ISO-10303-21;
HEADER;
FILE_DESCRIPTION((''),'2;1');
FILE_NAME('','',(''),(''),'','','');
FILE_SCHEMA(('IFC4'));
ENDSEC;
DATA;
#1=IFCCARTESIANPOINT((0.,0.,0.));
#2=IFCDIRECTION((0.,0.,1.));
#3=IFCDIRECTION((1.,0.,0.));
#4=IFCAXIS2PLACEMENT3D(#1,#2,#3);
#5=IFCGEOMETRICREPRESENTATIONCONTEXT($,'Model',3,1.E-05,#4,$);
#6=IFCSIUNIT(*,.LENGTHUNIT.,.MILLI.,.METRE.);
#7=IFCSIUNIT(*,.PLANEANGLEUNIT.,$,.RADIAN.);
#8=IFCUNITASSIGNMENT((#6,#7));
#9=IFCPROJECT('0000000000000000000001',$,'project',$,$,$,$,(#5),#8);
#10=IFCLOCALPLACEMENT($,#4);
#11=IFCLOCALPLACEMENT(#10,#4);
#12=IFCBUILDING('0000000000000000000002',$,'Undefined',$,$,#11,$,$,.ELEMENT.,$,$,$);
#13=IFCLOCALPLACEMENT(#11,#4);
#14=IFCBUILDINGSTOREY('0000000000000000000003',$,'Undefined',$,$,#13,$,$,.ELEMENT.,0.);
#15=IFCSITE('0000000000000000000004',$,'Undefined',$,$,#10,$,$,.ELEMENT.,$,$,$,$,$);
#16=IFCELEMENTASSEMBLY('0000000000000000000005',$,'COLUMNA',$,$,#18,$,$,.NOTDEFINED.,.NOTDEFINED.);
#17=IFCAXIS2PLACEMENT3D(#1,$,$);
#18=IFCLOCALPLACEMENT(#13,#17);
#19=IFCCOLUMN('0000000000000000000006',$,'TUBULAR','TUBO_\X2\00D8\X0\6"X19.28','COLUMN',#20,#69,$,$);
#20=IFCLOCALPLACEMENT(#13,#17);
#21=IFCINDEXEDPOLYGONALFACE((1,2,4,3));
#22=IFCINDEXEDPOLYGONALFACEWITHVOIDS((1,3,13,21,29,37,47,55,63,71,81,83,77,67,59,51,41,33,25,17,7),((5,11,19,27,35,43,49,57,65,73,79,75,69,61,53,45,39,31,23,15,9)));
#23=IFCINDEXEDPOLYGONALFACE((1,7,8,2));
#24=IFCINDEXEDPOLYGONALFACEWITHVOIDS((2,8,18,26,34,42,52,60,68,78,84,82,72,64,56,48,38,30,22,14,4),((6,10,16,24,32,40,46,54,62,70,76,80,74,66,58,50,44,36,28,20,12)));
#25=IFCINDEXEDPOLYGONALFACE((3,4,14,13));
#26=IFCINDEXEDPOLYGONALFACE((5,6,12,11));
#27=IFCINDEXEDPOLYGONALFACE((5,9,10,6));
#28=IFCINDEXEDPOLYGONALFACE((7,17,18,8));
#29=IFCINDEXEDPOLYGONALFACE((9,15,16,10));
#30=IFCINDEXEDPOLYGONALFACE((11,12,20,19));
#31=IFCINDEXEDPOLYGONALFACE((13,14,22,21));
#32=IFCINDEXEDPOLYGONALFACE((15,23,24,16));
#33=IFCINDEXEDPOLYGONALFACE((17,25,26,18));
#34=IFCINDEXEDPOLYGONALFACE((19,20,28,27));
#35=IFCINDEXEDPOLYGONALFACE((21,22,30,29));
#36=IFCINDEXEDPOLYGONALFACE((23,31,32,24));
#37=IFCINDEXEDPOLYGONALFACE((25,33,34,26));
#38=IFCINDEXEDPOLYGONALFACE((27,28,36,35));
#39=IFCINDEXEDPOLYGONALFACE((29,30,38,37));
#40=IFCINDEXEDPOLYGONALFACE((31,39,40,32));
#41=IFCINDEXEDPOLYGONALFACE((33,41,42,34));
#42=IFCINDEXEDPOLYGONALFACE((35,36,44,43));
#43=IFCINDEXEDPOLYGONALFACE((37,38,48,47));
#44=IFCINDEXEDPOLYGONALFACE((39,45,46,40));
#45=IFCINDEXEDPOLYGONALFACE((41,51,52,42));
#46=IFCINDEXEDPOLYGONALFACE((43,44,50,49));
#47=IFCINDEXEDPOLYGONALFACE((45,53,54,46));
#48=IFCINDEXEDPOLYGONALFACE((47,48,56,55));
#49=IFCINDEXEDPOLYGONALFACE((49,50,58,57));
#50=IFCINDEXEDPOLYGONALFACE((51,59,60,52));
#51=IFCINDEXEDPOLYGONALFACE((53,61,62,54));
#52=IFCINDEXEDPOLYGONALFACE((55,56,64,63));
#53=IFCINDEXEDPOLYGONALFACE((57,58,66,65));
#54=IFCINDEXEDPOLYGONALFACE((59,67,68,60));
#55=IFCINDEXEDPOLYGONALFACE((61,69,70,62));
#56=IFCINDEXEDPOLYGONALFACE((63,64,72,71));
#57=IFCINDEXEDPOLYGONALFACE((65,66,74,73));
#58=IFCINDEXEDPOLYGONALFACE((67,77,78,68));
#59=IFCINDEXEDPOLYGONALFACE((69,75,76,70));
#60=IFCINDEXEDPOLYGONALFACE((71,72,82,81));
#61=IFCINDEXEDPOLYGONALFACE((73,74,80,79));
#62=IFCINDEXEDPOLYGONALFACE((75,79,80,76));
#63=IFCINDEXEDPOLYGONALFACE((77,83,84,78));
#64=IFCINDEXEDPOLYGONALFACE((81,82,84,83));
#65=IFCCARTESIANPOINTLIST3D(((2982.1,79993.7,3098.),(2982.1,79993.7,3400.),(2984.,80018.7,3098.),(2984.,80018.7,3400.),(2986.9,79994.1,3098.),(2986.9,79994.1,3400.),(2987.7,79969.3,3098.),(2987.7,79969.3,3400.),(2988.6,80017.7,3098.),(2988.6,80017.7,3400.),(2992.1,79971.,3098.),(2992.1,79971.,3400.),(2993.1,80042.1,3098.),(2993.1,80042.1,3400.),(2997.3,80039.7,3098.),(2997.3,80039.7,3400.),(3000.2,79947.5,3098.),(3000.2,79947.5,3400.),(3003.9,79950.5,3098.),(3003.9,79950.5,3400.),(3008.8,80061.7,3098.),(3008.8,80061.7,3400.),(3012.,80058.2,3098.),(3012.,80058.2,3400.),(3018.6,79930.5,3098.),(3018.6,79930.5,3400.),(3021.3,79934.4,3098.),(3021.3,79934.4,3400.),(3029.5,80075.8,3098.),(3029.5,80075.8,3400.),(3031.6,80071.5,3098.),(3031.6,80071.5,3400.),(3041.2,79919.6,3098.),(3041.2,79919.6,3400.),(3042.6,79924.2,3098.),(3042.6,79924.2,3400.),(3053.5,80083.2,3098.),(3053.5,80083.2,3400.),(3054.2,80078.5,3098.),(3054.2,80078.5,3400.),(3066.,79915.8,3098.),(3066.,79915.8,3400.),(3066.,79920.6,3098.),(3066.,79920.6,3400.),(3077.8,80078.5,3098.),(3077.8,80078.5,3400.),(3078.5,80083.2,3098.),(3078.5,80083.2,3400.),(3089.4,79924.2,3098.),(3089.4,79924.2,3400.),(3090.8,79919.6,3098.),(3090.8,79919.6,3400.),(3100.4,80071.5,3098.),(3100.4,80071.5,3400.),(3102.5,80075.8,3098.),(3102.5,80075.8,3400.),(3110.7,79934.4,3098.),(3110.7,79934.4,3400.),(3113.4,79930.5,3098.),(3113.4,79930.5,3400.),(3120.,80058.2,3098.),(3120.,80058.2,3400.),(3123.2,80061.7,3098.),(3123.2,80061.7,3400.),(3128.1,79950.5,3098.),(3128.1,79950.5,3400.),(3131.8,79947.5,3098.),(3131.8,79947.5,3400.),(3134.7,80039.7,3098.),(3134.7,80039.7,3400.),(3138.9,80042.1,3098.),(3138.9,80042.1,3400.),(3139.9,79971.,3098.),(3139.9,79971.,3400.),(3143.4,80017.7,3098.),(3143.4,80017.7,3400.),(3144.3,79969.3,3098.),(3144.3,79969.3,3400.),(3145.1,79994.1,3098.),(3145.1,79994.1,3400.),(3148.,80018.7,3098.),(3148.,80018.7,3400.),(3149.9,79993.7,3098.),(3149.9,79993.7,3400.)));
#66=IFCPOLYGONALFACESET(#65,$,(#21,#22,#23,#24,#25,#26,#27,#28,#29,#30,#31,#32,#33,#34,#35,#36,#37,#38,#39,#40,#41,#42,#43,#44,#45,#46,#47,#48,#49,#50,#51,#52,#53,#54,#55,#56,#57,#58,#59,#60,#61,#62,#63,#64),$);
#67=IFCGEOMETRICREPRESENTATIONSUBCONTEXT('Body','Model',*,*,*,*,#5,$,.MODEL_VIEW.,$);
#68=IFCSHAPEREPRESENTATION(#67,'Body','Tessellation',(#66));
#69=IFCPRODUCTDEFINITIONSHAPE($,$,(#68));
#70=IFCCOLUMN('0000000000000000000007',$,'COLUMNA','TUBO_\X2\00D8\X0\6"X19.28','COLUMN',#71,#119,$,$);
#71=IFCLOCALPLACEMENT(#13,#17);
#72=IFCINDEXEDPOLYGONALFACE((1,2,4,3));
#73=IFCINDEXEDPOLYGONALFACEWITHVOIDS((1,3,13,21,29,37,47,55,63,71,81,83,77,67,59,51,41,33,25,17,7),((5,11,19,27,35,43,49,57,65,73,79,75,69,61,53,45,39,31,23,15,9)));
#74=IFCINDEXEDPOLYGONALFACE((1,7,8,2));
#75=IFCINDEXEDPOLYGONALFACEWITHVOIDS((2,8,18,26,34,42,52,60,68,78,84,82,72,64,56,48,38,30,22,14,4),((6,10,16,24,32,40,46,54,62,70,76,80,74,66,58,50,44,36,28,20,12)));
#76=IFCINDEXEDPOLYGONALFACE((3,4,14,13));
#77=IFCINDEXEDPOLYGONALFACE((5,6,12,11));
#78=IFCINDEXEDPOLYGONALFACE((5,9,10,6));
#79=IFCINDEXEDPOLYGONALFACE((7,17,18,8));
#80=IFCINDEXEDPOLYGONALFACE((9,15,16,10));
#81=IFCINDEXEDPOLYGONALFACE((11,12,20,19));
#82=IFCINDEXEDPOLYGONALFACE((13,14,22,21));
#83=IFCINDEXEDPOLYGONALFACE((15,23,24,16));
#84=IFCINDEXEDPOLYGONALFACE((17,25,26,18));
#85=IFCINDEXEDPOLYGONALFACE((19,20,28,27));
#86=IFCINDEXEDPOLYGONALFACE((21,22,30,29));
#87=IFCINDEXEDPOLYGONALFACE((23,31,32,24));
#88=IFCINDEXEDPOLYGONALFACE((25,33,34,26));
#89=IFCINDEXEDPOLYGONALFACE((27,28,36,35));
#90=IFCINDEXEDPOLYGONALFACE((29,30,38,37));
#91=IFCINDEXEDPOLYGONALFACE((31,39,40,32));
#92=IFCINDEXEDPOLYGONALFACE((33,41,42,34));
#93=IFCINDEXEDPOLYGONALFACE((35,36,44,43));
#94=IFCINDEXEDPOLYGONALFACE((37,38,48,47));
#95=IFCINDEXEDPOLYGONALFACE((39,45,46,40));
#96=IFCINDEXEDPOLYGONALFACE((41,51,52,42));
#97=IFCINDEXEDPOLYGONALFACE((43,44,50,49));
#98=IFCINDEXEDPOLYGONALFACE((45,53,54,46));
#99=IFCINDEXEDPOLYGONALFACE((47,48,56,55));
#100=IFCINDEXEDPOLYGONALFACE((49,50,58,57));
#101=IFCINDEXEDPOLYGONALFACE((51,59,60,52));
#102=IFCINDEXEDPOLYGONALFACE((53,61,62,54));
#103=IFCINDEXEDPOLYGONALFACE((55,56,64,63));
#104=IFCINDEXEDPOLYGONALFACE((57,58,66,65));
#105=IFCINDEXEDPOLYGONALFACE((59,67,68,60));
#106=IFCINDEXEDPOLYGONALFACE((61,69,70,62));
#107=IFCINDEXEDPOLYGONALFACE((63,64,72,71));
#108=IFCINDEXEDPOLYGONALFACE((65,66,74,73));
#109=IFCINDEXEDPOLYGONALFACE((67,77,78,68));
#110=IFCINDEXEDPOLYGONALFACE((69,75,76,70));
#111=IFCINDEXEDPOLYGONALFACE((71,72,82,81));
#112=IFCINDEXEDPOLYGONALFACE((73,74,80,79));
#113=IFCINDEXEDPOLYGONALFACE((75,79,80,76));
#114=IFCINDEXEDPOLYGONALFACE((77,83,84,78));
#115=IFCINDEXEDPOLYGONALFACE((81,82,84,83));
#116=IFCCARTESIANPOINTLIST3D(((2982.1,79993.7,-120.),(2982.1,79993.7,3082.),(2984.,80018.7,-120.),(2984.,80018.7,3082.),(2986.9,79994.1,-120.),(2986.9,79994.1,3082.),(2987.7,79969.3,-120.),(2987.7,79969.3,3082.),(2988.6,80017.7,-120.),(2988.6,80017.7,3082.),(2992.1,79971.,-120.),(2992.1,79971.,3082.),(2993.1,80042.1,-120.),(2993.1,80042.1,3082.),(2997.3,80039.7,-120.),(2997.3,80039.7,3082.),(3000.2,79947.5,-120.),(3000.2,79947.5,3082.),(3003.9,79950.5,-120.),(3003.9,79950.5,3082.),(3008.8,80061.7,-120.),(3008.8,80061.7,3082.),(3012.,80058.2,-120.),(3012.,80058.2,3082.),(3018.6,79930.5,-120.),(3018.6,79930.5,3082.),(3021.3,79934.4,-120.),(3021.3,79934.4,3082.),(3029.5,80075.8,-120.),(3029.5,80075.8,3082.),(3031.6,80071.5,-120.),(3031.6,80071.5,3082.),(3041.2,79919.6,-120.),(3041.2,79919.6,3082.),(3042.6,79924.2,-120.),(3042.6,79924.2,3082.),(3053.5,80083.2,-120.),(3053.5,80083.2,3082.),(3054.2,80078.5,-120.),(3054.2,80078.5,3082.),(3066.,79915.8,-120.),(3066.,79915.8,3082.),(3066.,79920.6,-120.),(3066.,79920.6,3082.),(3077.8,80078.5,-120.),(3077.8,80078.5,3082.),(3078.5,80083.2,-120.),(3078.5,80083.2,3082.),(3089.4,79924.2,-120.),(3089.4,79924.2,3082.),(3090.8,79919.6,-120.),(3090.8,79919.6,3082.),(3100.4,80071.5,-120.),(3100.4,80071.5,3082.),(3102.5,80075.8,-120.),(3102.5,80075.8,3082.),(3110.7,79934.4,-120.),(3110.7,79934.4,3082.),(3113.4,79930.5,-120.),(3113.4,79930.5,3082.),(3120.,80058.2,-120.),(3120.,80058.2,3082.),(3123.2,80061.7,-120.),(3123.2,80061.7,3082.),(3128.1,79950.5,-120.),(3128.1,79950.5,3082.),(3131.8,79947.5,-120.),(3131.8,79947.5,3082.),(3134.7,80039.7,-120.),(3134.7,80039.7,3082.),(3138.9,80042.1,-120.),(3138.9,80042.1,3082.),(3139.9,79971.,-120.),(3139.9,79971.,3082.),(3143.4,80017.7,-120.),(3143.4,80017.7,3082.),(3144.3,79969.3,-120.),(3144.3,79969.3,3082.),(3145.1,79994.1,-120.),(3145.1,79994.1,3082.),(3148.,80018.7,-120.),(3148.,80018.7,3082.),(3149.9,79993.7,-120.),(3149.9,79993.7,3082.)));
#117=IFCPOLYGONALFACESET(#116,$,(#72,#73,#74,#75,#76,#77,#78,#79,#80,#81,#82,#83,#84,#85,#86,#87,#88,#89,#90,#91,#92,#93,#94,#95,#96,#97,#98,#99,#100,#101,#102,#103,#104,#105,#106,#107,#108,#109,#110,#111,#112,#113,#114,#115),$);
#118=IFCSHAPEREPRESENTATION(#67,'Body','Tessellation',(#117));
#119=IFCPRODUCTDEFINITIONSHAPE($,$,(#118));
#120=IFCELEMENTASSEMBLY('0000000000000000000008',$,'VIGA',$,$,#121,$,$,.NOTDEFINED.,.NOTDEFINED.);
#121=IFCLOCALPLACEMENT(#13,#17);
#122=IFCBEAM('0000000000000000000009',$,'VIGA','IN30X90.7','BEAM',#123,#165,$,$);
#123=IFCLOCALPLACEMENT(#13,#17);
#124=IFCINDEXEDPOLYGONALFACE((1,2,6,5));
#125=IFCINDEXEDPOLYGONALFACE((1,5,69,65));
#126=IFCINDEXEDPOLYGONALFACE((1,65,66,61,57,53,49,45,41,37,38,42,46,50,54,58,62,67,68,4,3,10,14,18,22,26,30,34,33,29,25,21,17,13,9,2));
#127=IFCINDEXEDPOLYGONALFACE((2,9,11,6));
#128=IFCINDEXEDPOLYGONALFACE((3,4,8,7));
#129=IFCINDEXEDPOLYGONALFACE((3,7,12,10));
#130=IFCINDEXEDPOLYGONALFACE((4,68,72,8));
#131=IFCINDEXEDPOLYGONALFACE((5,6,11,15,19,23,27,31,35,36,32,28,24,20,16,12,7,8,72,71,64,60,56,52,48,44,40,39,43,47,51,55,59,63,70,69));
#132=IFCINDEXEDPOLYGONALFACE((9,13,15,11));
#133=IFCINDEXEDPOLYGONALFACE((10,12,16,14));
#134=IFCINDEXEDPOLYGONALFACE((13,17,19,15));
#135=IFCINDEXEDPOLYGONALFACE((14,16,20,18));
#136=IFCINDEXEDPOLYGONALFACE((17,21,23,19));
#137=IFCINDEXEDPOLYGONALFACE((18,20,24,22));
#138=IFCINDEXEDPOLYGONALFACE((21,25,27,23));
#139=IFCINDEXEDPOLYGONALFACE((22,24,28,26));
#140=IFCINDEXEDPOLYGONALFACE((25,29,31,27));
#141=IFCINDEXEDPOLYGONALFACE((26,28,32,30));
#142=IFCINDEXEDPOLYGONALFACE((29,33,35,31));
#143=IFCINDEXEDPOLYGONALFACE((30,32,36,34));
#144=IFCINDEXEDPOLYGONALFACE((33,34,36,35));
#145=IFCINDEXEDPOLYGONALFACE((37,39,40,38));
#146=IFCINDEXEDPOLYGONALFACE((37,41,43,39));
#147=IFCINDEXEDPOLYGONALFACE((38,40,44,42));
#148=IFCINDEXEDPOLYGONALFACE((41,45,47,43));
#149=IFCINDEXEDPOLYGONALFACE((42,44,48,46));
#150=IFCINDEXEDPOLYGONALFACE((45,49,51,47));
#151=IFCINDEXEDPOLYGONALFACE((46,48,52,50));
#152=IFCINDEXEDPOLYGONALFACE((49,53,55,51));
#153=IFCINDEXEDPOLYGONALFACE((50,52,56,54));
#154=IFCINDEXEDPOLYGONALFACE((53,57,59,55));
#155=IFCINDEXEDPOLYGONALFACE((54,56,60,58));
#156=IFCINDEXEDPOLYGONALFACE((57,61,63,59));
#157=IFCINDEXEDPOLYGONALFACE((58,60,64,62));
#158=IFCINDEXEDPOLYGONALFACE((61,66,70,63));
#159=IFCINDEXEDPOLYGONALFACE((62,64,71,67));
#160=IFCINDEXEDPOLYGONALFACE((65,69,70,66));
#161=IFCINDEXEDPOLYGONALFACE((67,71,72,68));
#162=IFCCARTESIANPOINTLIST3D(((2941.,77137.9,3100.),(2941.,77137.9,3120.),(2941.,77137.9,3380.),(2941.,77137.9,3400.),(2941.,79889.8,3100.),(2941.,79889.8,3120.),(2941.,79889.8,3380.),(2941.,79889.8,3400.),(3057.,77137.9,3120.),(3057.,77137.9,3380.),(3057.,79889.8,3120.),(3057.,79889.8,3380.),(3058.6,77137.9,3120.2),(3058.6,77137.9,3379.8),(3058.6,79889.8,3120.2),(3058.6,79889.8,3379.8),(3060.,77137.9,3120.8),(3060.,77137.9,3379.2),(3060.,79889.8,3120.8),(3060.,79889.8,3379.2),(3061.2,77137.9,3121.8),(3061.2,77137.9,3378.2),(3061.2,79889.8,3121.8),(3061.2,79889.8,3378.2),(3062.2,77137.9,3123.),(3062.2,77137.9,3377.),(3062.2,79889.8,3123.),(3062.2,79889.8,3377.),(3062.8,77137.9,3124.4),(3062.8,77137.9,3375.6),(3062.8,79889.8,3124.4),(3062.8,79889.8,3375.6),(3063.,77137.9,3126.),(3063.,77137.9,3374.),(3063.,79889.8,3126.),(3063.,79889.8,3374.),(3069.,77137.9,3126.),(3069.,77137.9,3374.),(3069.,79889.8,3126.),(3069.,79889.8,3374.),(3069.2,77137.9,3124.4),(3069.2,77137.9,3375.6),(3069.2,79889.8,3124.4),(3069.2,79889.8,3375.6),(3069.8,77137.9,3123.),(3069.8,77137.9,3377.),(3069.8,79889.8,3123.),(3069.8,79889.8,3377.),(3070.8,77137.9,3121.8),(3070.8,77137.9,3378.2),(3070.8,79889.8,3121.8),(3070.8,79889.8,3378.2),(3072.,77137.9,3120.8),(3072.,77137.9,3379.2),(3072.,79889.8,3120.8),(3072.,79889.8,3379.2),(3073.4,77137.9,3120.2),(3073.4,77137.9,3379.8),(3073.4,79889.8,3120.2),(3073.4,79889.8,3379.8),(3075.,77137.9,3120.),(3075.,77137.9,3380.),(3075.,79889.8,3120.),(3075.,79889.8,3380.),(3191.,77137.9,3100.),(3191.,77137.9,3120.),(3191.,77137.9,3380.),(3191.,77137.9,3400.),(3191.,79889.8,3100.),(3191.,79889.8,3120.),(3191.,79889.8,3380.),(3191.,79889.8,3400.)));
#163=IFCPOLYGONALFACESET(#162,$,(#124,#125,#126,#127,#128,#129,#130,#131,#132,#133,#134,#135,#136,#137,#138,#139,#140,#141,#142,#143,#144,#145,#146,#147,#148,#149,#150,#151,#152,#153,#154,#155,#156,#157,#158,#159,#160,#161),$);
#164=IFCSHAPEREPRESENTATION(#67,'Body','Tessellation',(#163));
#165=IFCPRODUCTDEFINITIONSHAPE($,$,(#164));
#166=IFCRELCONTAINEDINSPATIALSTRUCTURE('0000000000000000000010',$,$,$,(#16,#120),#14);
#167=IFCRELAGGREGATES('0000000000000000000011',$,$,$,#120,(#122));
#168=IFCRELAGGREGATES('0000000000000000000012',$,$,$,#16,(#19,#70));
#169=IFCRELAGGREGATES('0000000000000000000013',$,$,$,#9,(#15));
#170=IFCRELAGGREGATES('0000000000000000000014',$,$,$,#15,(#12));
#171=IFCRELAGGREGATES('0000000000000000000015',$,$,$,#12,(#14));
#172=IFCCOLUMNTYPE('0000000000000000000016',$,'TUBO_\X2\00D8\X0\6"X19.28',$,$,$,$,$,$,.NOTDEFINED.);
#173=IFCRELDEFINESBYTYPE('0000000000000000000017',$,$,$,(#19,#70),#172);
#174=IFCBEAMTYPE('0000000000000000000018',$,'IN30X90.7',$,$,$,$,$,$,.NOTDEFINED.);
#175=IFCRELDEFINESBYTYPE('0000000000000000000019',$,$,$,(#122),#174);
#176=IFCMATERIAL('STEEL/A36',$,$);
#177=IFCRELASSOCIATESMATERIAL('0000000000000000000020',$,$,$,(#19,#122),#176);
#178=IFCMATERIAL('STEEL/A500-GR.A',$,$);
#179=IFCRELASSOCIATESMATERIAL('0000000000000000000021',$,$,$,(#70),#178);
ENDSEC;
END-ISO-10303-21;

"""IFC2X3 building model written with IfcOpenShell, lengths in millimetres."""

from ifc_helpers import new_model, si_unit, frame, origin_with_axes, origin_2d_with_axis, place, context, subcontext, project, spatial, hollow_circle, i_section, extrude, material, type_object, element, aggregate, save


model = new_model("IFC2X3")

# Units and contexts
model_context = context("Model", 3, precision=1e-05, world=origin_with_axes())
body_context = subcontext(model_context, "Body", "Model", "MODEL_VIEW")
ifc_project = project(units=[si_unit("LENGTHUNIT", "METRE", prefix="MILLI"), si_unit("PLANEANGLEUNIT", "RADIAN")], contexts=[model_context])

# Site, building, storey
site_placement = place(None, origin_with_axes())
site = spatial("IfcSite", under=ifc_project, at=site_placement, Name="Undefined", CompositionType="ELEMENT")
building_placement = place(site_placement, origin_with_axes())
building = spatial("IfcBuilding", under=site, at=building_placement, Name="Undefined", CompositionType="ELEMENT")
storey_placement = place(building_placement, origin_with_axes())
storey = spatial("IfcBuildingStorey", under=building, at=storey_placement, Name="Undefined", CompositionType="ELEMENT", Elevation=0.0)

# Element assembly, columns
assembly_1_placement = place(storey_placement, origin_with_axes())
assembly_1 = element("IfcElementAssembly", 1, at=assembly_1_placement, inside=storey, Name="COLUMNA", AssemblyPlace="NOTDEFINED", PredefinedType="NOTDEFINED")
ifc_material_1 = material(Name="STEEL/A36")
column_type = type_object("IfcColumnType", Name="TUBO_Ø6\"X19.28", PredefinedType="NOTDEFINED")
column_1_placement = place(assembly_1_placement, frame((3066.0, 80000.0, 3098.0), z_axis=(0.0, 0.0, 1.0), x_axis=(-1.0, 0.0, 0.0)))
column_1 = element("IfcColumn", 2, at=column_1_placement, type_object=column_type, material=ifc_material_1, Name="TUBULAR", Description="TUBO_Ø6\"X19.28", ObjectType="COLUMN", context=body_context, shape_type="SweptSolid", body=[
    extrude(hollow_circle(Radius=84.2, WallThickness=4.8, at=origin_2d_with_axis()), frame((0.0, 0.0, 302.0), z_axis=(0.0, 0.0, -1.0), x_axis=(0.0, 1.0, 0.0)), (0.0, 0.0, 1.0), 302.0),
])
ifc_material_2 = material(Name="STEEL/A500-GR.A")
column_2_placement = place(assembly_1_placement, frame((3066.0, 80000.0, -120.0), z_axis=(0.0, 0.0, 1.0), x_axis=(-1.0, 0.0, 0.0)))
column_2 = element("IfcColumn", 3, at=column_2_placement, type_object=column_type, material=ifc_material_2, Name="COLUMNA", Description="TUBO_Ø6\"X19.28", ObjectType="COLUMN", context=body_context, shape_type="SweptSolid", body=[
    extrude(hollow_circle(Radius=84.2, WallThickness=4.8, at=origin_2d_with_axis()), frame((0.0, 0.0, 3202.0), z_axis=(0.0, 0.0, -1.0), x_axis=(0.0, 1.0, 0.0)), (0.0, 0.0, 1.0), 3202.0),
])

# Element assembly, beam
assembly_2_placement = place(storey_placement, origin_with_axes())
assembly_2 = element("IfcElementAssembly", 4, at=assembly_2_placement, inside=storey, Name="VIGA", AssemblyPlace="NOTDEFINED", PredefinedType="NOTDEFINED")
beam_type_1 = type_object("IfcBeamType", Name="IN30X90.7", PredefinedType="NOTDEFINED")
beam_1_placement = place(assembly_2_placement, frame((3066.0, 79889.8, 3250.0), z_axis=(0.0, 0.0, 1.0), x_axis=(0.0, -1.0, 0.0)))
beam_1 = element("IfcBeam", 5, at=beam_1_placement, type_object=beam_type_1, material=ifc_material_1, Name="VIGA", Description="IN30X90.7", ObjectType="BEAM", context=body_context, shape_type="SweptSolid", body=[
    extrude(i_section(OverallWidth=250.0, OverallDepth=300.0, WebThickness=6.0, FlangeThickness=20.0, FilletRadius=6.0, at=origin_2d_with_axis()), frame((2751.9, 0.0, 0.0), z_axis=(-1.0, 0.0, 0.0), x_axis=(0.0, -1.0, 0.0)), (0.0, 0.0, 1.0), 2751.9),
])
aggregate(assembly_2, [beam_1])

aggregate(assembly_1, [column_1, column_2])

save(model, "model.ifc")
